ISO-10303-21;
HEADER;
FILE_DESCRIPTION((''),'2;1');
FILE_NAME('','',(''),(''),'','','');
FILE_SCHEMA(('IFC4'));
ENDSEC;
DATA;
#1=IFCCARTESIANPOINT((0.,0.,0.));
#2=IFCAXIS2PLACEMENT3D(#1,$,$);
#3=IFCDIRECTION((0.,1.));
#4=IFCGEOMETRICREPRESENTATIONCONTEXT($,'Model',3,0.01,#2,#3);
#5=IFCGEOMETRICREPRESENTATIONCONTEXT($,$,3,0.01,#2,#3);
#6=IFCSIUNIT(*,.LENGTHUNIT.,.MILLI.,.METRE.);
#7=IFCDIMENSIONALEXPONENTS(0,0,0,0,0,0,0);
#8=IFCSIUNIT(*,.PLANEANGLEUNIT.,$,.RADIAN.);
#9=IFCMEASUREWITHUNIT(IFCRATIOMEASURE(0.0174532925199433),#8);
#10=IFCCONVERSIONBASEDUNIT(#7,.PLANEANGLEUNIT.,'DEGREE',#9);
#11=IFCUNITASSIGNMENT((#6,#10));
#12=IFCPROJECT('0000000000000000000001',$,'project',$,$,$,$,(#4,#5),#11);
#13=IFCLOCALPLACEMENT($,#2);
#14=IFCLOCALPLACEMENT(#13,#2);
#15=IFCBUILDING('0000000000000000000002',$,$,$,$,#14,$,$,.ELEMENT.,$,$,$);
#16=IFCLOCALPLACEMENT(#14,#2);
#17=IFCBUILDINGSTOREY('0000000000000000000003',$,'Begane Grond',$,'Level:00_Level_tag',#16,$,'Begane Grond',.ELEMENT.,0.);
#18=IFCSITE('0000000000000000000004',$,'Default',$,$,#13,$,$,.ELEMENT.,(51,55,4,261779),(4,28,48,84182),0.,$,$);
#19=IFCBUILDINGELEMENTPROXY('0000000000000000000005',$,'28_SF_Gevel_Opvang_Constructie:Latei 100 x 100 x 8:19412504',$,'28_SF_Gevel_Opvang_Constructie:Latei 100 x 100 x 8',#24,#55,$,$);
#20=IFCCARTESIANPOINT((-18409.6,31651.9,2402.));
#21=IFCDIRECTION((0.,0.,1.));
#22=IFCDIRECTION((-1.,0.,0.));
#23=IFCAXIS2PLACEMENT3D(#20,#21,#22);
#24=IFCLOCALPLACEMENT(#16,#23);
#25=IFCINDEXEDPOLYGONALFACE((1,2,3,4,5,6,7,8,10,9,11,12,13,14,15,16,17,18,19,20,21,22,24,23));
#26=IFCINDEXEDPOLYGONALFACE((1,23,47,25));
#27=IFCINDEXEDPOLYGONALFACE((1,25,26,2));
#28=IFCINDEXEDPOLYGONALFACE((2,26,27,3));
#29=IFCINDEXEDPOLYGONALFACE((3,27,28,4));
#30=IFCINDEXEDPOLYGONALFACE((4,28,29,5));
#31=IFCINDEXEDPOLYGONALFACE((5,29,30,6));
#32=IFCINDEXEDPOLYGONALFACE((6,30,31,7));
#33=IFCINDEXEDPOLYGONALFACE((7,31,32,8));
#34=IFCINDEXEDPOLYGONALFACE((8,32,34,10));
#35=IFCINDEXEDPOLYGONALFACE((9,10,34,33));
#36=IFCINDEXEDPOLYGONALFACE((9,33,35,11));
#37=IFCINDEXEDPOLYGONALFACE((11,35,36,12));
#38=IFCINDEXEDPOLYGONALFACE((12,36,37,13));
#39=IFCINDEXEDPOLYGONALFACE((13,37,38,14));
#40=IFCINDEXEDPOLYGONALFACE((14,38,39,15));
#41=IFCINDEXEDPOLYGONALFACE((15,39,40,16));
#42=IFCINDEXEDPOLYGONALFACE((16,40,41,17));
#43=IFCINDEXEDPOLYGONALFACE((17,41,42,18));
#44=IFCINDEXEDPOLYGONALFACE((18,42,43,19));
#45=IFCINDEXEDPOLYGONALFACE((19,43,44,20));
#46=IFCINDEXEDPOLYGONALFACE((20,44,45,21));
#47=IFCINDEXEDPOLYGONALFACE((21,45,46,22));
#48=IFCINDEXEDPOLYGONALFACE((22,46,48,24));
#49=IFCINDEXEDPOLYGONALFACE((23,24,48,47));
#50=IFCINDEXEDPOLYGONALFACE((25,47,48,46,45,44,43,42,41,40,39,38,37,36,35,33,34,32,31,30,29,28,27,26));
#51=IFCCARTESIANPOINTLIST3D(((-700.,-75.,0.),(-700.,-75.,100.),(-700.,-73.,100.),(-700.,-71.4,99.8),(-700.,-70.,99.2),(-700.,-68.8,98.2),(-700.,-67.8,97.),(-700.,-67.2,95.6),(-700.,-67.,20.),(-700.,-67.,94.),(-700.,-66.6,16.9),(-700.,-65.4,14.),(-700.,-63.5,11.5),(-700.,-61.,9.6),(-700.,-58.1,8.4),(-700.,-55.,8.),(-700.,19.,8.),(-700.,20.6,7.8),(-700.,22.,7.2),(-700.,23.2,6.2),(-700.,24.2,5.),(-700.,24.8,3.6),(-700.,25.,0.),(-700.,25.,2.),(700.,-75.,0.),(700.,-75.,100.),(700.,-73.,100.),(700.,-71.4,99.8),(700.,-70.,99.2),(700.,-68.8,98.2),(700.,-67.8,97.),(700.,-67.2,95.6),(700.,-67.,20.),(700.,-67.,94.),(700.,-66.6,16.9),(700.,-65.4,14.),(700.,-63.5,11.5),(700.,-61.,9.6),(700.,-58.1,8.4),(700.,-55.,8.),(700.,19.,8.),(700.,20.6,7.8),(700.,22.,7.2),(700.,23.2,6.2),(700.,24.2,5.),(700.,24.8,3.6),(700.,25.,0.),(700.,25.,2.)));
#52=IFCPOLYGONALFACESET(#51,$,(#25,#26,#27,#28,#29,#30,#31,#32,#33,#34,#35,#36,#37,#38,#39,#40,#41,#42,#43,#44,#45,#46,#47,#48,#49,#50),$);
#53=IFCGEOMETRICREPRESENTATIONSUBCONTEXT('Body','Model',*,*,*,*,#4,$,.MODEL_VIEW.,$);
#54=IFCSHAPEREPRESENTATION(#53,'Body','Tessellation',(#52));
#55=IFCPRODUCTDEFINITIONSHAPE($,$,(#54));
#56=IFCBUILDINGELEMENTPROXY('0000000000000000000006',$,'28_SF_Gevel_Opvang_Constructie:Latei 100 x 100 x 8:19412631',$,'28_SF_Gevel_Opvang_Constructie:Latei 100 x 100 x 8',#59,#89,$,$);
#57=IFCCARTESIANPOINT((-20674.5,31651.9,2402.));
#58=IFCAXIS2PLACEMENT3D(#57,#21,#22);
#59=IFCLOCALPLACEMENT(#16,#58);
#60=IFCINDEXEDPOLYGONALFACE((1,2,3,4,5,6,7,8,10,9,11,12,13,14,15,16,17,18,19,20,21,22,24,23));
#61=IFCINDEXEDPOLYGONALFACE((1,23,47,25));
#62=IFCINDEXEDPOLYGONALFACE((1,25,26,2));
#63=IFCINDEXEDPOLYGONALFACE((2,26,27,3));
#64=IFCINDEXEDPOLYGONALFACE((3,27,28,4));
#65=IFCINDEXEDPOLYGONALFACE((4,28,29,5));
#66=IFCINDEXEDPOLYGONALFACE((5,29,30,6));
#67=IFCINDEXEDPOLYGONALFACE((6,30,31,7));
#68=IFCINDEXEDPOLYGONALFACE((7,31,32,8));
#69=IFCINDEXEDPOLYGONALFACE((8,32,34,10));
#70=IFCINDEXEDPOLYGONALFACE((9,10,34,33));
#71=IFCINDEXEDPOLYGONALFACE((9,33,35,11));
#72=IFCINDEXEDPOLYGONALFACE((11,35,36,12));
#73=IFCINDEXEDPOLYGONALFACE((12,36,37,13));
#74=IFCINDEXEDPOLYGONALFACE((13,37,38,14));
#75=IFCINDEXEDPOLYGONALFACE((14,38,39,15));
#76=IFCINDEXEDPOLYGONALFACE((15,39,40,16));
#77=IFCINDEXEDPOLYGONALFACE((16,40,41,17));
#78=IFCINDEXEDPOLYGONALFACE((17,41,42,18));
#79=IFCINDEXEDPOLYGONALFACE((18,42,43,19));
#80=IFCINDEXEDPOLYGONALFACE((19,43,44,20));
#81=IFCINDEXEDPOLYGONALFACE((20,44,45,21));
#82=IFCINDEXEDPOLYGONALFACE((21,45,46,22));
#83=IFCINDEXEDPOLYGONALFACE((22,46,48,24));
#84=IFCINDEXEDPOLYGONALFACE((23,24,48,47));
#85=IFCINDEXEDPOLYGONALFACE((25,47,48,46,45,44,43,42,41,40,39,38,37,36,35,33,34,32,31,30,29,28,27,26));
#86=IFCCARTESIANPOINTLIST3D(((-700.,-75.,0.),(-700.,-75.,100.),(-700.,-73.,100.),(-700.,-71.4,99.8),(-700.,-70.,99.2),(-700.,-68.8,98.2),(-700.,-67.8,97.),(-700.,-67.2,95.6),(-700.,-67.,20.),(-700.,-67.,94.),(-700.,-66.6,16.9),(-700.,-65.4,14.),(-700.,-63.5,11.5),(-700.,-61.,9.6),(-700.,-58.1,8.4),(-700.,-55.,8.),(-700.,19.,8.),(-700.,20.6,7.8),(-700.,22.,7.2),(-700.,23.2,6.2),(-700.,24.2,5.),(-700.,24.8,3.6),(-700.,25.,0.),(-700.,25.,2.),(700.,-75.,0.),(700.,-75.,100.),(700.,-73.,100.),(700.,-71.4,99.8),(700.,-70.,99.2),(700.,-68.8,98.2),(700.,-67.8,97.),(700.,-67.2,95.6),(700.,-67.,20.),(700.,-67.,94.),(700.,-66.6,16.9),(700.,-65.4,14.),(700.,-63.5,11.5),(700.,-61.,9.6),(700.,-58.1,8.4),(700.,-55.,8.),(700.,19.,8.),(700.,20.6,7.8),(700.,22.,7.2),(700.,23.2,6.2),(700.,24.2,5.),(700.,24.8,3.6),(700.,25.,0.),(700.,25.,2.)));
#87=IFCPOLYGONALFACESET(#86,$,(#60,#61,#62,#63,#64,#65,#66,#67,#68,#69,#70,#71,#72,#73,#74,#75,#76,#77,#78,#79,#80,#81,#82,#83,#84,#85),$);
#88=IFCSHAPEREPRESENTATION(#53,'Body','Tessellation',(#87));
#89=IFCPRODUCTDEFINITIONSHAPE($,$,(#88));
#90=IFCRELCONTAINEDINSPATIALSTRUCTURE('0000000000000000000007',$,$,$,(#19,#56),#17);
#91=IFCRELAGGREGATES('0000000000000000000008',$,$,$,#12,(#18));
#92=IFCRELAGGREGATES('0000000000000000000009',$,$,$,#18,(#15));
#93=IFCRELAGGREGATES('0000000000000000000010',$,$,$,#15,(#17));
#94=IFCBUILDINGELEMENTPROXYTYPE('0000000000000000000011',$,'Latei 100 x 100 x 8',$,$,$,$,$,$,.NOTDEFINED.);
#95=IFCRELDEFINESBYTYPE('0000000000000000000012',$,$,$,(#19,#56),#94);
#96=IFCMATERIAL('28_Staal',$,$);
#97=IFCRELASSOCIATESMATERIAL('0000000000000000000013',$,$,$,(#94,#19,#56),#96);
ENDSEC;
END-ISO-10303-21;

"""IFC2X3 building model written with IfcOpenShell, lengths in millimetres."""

from ifc_helpers import new_model, entity, si_unit, converted_unit, direction, frame, frame_2d, origin, place, context, subcontext, project, spatial, polyline, circle_curve, parameter, trimmed, segment, composite_curve, outline, extrude, source, transform, mapped, material, type_object, type_shapes, element, save


model = new_model("IFC2X3")

# Units and contexts
model_context = context("Model", 3, precision=0.01, world=origin(), true_north=direction((0.0, 1.0)))
context_of_model = context(None, 3, precision=0.01, world=origin(), true_north=direction((0.0, 1.0)))
body_context = subcontext(model_context, "Body", "Model", "MODEL_VIEW")
ifc_project = project(units=[si_unit("LENGTHUNIT", "METRE", prefix="MILLI"), converted_unit("PLANEANGLEUNIT", "DEGREE", entity("IfcRatioMeasure", 0.0174532925199433), si_unit("PLANEANGLEUNIT", "RADIAN"), dimensions=[0, 0, 0, 0, 0, 0, 0])], contexts=[model_context, context_of_model])

# Site, building, storey
site_placement = place(None, origin())
site = spatial("IfcSite", under=ifc_project, at=site_placement, Name="Default", CompositionType="ELEMENT", RefLatitude=(51, 55, 4, 261779), RefLongitude=(4, 28, 48, 84182), RefElevation=0.0)
building_placement = place(site_placement, origin())
building = spatial("IfcBuilding", under=site, at=building_placement, CompositionType="ELEMENT")
storey_placement = place(building_placement, origin())
storey = spatial("IfcBuildingStorey", under=building, at=storey_placement, Name="Begane Grond", ObjectType="Level:00_Level_tag", LongName="Begane Grond", CompositionType="ELEMENT", Elevation=0.0)

# Building element proxies
ifc_material_1 = material(Name="28_Staal")
building_element_proxy_type_1 = type_object("IfcBuildingElementProxyType", Name="Latei 100 x 100 x 8", PredefinedType="NOTDEFINED", material=ifc_material_1)
shared_shape_1 = source(origin(), body_context, "Body", "SweptSolid", [
    extrude(outline(composite_curve([segment(polyline([(-36.9, -36.9), (63.1, -36.9)]), True, "CONTINUOUS"), segment(polyline([(63.1, -36.9), (63.1, -34.9)]), True, "CONTINUOUS"), segment(trimmed(circle_curve(frame_2d((57.1, -34.9), x_axis=(1.0, 0.0)), 6.0), [parameter(0.0)], [parameter(90.0)], True, "PARAMETER"), True, "CONTINUOUS"), segment(polyline([(57.1, -28.9), (-16.9, -28.9)]), True, "CONTINUOUS"), segment(trimmed(circle_curve(frame_2d((-16.9, -16.9), x_axis=(1.0, 0.0)), 12.0), [parameter(180.0)], [parameter(270.0)], True, "PARAMETER"), False, "CONTINUOUS"), segment(polyline([(-28.9, -16.9), (-28.9, 57.1)]), True, "CONTINUOUS"), segment(trimmed(circle_curve(frame_2d((-34.9, 57.1), x_axis=(1.0, 0.0)), 6.0), [parameter(0.0)], [parameter(90.0)], True, "PARAMETER"), True, "CONTINUOUS"), segment(polyline([(-34.9, 63.1), (-36.9, 63.1)]), True, "CONTINUOUS"), segment(polyline([(-36.9, 63.1), (-36.9, -36.9)]), True, "CONTINUOUS")], self_intersect=False)), frame((-700.0, -38.1, 36.9), z_axis=(1.0, 0.0, 0.0), x_axis=(0.0, 1.0, 0.0)), (0.0, 0.0, 1.0), 1400.0),
])
type_shapes(building_element_proxy_type_1, [shared_shape_1])
for number, where, z_axis, x_axis, name in (
    (1, (-18409.6, 31651.9, 2402.0), (0.0, 0.0, 1.0), (-1.0, 0.0, 0.0), "28_SF_Gevel_Opvang_Constructie:Latei 100 x 100 x 8:19412504"),
    (2, (-20674.5, 31651.9, 2402.0), (0.0, 0.0, 1.0), (-1.0, 0.0, 0.0), "28_SF_Gevel_Opvang_Constructie:Latei 100 x 100 x 8:19412631"),
):
    element("IfcBuildingElementProxy", number, at=place(storey_placement, frame(where, z_axis=z_axis, x_axis=x_axis)), inside=storey, type_object=building_element_proxy_type_1, material=ifc_material_1, Name=name, ObjectType="28_SF_Gevel_Opvang_Constructie:Latei 100 x 100 x 8", context=body_context, shape_type="MappedRepresentation", body=[
        mapped(shared_shape_1, transform((0.0, 0.0, 0.0), scale=1.0)),
    ])

save(model, "model.ifc")
